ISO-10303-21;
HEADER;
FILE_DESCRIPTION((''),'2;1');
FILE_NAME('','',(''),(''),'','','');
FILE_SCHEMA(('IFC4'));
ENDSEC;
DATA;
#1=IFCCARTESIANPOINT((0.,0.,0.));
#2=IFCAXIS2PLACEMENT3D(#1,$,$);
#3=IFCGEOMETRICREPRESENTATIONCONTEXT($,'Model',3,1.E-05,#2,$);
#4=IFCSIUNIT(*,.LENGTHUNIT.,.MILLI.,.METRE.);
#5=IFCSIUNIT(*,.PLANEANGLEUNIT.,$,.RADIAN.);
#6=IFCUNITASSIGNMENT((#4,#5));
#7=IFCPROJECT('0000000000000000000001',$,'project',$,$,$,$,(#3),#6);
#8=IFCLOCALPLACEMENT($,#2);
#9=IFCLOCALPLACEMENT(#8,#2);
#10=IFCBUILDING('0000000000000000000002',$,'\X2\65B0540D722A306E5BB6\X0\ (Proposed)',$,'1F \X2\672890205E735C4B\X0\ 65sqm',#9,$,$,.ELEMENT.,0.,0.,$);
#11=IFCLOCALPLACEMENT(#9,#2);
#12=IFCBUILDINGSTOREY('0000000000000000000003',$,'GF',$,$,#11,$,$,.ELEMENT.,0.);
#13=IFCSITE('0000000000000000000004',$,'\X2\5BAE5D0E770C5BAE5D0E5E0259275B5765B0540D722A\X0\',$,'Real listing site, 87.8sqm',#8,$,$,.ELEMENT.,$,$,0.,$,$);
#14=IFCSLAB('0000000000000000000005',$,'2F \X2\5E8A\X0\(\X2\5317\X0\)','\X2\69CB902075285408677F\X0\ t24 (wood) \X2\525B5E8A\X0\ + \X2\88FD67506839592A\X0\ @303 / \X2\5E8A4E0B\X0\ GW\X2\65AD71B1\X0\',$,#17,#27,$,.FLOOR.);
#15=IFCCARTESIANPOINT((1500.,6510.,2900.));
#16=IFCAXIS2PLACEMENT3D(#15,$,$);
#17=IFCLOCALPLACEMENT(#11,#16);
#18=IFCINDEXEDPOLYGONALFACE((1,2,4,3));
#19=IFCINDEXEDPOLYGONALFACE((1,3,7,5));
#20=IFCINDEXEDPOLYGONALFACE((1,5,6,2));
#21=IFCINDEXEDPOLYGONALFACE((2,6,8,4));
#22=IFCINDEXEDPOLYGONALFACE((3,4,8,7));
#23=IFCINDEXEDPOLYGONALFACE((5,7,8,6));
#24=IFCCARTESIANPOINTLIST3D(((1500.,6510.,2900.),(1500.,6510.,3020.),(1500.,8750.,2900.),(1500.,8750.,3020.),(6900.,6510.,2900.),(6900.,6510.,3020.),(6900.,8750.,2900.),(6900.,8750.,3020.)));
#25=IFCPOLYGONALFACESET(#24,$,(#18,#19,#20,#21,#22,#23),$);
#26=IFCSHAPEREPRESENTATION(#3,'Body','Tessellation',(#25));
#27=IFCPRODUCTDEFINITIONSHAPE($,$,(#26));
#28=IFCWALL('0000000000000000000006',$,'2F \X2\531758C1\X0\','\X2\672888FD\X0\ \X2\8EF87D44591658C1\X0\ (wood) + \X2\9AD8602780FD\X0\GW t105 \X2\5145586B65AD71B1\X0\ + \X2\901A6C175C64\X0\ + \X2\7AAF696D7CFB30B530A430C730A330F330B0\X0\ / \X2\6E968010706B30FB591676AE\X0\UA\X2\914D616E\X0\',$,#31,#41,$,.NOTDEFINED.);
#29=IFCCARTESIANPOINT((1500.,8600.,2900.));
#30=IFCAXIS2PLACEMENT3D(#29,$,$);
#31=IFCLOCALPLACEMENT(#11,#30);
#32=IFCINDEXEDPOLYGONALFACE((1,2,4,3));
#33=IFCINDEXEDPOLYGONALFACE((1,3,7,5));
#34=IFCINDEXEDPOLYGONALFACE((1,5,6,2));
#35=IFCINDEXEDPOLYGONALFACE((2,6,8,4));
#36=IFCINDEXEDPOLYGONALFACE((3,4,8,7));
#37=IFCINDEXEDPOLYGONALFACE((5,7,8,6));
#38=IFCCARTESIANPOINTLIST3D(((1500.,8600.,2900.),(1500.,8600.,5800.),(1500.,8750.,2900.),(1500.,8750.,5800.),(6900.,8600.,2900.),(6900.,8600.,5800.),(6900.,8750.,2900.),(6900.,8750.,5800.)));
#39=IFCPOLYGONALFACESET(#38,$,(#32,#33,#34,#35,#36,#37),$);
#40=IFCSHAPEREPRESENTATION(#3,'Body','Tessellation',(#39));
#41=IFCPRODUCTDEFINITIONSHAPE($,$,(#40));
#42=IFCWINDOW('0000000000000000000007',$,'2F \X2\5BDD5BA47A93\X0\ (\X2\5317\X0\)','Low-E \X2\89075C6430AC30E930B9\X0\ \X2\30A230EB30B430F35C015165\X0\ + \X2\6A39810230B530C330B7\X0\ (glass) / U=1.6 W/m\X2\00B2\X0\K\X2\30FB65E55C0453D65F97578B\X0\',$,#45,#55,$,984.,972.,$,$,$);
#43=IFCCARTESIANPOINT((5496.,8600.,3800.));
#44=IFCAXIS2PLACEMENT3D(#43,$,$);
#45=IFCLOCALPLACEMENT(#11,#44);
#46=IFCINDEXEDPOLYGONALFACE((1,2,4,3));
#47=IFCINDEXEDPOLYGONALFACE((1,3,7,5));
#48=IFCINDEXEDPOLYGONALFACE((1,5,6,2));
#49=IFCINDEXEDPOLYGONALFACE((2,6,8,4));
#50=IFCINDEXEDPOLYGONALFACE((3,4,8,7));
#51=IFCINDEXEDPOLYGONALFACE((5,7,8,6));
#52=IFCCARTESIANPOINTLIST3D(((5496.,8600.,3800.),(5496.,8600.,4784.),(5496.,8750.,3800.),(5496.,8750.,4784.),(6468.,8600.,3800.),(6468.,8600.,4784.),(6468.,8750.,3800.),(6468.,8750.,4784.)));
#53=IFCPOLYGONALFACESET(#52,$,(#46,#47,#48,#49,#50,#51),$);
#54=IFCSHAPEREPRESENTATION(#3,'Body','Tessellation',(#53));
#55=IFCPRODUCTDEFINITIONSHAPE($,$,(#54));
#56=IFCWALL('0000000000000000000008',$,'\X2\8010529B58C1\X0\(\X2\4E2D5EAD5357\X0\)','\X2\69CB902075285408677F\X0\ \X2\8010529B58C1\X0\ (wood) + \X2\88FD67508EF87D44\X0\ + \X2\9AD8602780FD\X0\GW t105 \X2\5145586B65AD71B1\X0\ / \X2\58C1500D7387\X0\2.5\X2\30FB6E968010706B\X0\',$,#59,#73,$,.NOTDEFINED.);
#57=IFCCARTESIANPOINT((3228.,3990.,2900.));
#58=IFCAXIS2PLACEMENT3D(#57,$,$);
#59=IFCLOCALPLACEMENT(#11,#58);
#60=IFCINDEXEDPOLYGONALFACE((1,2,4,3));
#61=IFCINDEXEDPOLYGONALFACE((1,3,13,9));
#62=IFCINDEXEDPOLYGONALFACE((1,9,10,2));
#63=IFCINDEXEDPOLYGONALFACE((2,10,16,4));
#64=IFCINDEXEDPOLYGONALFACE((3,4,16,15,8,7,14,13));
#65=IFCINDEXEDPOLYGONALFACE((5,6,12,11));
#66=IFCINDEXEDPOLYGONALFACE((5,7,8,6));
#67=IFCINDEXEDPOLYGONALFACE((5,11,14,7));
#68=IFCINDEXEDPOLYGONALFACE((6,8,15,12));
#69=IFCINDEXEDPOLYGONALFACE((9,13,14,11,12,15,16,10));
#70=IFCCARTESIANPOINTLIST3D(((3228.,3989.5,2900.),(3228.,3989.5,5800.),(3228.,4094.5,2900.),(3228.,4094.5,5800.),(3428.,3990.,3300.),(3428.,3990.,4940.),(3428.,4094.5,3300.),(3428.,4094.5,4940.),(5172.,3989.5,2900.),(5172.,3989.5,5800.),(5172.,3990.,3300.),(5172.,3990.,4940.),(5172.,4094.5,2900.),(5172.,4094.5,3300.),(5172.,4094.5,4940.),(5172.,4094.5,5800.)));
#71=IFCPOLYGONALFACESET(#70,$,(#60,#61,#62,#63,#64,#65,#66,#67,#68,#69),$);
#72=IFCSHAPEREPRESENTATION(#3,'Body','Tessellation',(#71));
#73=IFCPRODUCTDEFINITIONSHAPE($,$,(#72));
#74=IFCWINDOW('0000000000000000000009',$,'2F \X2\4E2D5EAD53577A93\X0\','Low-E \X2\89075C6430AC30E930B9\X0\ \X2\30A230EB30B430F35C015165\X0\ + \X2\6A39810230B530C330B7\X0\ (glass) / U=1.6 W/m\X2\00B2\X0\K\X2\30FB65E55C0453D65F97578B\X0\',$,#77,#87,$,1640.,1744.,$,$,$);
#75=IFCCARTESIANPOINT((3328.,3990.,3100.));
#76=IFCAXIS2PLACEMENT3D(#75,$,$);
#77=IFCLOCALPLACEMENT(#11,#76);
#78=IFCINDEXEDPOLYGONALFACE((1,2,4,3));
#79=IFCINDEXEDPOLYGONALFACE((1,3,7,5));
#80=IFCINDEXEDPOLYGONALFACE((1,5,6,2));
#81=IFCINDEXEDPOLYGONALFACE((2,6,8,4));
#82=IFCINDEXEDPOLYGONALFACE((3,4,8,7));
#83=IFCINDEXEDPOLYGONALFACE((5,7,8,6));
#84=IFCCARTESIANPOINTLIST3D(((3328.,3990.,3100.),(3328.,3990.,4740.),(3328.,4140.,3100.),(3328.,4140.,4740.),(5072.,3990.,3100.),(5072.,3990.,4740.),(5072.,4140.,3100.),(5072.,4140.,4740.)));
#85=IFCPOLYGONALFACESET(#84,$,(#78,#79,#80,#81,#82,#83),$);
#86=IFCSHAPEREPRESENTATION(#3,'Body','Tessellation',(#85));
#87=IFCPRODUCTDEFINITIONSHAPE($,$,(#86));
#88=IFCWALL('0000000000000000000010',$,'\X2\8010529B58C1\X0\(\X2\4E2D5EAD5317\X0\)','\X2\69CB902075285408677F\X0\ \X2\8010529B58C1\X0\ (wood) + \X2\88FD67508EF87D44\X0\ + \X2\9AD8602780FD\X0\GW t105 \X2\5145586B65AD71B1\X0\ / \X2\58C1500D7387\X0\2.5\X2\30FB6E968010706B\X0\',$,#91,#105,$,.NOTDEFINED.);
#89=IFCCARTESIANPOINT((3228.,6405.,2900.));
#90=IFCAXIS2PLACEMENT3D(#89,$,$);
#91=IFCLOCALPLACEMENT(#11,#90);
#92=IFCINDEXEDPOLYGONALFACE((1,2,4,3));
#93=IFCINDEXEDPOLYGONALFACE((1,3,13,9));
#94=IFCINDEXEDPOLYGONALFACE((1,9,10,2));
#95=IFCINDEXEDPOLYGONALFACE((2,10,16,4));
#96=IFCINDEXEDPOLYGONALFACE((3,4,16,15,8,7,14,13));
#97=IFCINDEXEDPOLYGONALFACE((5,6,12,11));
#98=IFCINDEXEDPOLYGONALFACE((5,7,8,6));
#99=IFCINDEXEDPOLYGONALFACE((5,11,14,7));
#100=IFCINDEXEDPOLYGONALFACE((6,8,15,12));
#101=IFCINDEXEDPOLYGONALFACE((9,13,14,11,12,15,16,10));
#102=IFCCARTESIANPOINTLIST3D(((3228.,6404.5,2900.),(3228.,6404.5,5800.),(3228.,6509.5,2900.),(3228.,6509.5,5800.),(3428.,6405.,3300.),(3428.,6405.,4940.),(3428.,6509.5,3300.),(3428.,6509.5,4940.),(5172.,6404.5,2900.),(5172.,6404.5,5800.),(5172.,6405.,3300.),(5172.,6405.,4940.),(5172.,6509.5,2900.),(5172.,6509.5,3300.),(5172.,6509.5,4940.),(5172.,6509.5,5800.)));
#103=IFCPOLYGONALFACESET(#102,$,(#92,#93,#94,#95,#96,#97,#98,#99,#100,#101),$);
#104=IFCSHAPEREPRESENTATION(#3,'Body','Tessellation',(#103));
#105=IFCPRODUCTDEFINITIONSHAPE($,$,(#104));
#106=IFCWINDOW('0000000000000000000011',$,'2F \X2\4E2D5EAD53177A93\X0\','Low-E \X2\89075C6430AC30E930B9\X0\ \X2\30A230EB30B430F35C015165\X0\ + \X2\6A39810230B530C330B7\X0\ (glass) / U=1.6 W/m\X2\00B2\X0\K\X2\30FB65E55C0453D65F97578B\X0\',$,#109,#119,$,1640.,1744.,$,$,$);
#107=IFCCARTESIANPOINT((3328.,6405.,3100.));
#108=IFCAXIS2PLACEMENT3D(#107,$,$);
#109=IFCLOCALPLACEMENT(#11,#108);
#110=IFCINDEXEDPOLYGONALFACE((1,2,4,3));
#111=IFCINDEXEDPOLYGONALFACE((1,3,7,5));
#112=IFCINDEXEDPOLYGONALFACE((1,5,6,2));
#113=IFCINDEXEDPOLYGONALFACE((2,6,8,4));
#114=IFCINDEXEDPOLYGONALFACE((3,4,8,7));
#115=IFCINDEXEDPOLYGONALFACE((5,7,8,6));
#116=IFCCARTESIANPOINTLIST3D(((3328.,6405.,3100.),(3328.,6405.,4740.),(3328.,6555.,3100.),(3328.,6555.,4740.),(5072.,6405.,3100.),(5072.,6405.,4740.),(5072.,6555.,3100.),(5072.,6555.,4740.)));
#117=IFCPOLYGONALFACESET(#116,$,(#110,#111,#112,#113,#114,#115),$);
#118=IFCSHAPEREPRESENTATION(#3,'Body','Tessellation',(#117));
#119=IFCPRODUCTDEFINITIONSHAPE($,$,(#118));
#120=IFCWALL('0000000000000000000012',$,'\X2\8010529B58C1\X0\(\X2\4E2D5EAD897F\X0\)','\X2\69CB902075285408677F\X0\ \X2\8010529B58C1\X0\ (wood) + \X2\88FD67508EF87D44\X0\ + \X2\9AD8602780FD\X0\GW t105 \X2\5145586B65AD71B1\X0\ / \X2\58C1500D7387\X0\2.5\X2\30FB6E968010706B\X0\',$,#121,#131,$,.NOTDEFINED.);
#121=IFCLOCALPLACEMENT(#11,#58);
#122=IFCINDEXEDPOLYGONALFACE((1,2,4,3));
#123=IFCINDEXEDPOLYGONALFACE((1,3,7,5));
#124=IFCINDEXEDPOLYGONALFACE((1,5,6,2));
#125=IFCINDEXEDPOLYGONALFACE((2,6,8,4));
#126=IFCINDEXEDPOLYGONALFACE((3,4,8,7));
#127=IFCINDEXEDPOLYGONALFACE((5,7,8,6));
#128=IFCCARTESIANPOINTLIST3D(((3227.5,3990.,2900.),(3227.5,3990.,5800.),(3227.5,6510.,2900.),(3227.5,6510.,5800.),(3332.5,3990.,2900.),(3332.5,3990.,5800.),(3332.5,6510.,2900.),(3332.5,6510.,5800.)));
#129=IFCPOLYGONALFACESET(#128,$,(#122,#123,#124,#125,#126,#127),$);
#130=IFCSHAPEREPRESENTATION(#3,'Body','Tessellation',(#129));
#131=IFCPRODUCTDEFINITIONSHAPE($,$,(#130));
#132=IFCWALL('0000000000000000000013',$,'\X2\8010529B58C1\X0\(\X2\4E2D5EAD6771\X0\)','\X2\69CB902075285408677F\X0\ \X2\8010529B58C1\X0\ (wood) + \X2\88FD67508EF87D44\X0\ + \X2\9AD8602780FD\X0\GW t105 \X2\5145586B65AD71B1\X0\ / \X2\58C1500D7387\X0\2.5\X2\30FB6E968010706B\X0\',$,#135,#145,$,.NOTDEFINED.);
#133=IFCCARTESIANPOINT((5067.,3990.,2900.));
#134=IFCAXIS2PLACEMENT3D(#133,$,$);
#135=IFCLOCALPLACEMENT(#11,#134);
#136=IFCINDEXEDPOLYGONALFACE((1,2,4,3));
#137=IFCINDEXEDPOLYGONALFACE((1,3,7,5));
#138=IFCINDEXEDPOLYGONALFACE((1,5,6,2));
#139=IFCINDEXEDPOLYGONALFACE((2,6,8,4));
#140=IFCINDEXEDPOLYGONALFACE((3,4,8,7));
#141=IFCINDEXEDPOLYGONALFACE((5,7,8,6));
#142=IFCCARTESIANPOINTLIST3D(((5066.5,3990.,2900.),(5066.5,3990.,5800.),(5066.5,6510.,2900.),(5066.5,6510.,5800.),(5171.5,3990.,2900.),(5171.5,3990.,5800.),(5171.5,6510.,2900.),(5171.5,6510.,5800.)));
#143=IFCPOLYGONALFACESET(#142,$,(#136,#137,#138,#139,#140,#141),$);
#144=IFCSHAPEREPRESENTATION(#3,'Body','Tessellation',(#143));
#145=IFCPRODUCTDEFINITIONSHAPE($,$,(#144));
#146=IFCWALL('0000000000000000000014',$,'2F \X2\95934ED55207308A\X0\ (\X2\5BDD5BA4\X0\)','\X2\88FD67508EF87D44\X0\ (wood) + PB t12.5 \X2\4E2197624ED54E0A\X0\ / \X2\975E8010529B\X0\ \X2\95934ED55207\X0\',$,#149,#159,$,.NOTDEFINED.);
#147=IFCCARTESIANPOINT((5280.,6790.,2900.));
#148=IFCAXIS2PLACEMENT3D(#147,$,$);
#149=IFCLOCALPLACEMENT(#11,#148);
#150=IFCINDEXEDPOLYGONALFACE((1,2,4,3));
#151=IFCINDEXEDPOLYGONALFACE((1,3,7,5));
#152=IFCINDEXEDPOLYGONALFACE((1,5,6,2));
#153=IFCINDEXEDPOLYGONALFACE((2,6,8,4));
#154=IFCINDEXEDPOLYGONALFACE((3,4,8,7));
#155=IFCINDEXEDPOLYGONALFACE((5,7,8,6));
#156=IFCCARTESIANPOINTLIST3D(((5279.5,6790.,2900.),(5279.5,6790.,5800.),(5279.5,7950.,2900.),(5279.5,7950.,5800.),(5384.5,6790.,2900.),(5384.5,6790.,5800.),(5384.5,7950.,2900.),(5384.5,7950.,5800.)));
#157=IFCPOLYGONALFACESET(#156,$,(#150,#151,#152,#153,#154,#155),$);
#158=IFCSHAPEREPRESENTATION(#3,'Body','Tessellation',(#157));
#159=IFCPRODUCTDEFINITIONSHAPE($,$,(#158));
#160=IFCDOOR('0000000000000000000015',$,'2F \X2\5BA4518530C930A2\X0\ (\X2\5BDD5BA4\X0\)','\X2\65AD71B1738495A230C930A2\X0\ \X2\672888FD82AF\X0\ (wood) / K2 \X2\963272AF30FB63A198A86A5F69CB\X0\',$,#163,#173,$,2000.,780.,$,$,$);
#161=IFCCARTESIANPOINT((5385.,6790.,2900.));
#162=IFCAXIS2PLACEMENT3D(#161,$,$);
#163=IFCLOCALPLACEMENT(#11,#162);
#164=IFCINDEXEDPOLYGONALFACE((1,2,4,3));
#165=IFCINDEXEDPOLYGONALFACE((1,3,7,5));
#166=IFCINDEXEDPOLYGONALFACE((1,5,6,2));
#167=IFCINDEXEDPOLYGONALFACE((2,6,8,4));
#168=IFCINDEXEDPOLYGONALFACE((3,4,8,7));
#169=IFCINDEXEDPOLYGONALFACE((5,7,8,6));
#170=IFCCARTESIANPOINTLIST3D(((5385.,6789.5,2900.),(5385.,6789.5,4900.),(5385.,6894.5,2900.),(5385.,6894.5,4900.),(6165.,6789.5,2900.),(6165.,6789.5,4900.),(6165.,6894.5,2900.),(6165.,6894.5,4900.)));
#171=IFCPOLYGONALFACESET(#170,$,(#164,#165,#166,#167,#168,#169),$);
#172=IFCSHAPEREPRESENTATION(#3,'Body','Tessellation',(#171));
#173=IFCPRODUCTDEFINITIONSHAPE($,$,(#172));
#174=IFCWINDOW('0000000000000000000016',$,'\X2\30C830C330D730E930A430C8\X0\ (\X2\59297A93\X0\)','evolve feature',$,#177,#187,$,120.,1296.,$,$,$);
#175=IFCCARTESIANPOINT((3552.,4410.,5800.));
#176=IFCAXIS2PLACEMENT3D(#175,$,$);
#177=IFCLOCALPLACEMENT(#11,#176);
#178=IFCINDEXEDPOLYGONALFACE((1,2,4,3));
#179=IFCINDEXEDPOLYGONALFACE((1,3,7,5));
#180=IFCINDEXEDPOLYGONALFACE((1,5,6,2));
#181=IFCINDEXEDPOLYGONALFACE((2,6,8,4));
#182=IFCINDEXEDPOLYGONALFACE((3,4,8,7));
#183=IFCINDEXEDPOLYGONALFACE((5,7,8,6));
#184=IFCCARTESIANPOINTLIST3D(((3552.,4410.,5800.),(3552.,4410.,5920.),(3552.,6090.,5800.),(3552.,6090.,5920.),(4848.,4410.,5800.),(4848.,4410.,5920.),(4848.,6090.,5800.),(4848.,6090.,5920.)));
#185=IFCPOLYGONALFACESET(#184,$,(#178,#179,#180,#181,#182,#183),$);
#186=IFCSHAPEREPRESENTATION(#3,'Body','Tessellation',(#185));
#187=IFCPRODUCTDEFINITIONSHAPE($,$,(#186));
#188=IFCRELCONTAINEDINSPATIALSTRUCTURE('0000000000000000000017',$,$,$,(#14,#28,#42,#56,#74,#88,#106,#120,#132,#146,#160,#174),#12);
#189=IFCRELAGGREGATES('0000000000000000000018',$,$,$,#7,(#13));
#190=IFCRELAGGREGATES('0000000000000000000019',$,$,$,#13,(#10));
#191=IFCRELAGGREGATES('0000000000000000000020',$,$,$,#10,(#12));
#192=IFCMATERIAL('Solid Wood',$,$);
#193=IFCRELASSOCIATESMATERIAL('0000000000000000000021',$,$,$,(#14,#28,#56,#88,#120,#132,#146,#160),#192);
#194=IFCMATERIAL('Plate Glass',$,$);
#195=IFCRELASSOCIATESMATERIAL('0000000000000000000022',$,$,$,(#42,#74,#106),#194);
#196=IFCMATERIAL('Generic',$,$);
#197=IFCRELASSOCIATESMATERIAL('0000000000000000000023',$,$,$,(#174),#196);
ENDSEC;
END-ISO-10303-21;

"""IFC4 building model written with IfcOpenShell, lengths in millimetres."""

from ifc_helpers import new_model, si_unit, frame, frame_2d, origin, place, context, project, spatial, rectangle, extrude, material, element, fill, save


model = new_model("IFC4")

# Units and contexts
model_context = context("Model", 3, precision=1e-05, world=origin())
ifc_project = project(units=[si_unit("LENGTHUNIT", "METRE", prefix="MILLI"), si_unit("PLANEANGLEUNIT", "RADIAN")], contexts=[model_context])

# Site, building, storey
site_placement = place(None, origin())
site = spatial("IfcSite", under=ifc_project, at=site_placement, Name="宮崎県宮崎市大字新名爪", ObjectType="Real listing site, 87.8sqm", CompositionType="ELEMENT", RefElevation=0.0)
building_placement = place(site_placement, origin())
building = spatial("IfcBuilding", under=site, at=building_placement, Name="新名爪の家 (Proposed)", ObjectType="1F 木造平屋 65sqm", CompositionType="ELEMENT", ElevationOfRefHeight=0.0, ElevationOfTerrain=0.0)
storey_placement = place(building_placement, origin())
storey = spatial("IfcBuildingStorey", under=building, at=storey_placement, Name="GF", CompositionType="ELEMENT", Elevation=0.0)

# Slab
ifc_material_1 = material(Name="Solid Wood")
slab_placement = place(storey_placement, frame((1500.0, 6510.0, 2900.0)))
element("IfcSlab", 1, at=slab_placement, inside=storey, material=ifc_material_1, Name="2F 床(北)", Description="構造用合板 t24 (wood) 剛床 + 製材根太 @303 / 床下 GW断熱", PredefinedType="FLOOR", context=model_context, shape_type="SweptSolid", body=[
    extrude(rectangle(XDim=5400.0, YDim=2240.0, at=frame_2d((2700.0, 1120.0))), frame((1500.0, 6510.0, 2900.0)), (0.0, 0.0, 1.0), 120.0),
])

# Walls, openings, windows
wall_1_placement = place(storey_placement, frame((1500.0, 8600.0, 2900.0)))
wall_1 = element("IfcWall", 2, at=wall_1_placement, inside=storey, material=ifc_material_1, Name="2F 北壁", Description="木製 軸組外壁 (wood) + 高性能GW t105 充填断熱 + 通気層 + 窯業系サイディング / 準耐火・外皮UA配慮", PredefinedType="NOTDEFINED", context=model_context, shape_type="SweptSolid", body=[
    extrude(rectangle(XDim=5400.0, YDim=150.0, at=frame_2d((2700.0, 75.0))), frame((1500.0, 8600.0, 2900.0)), (0.0, 0.0, 1.0), 2900.0),
])
opening_1_placement = place(storey_placement, frame((5496.0, 8600.0, 3800.0)))
opening_1 = element("IfcOpeningElement", 3, at=opening_1_placement, cuts=wall_1, PredefinedType="NOTDEFINED", context=model_context, shape_type="SweptSolid", body=[
    extrude(rectangle(XDim=972.0, YDim=150.0, at=frame_2d((486.0, 75.0))), frame((5496.0, 8600.0, 3800.0)), (0.0, 0.0, 1.0), 984.0),
])
ifc_material_2 = material(Name="Plate Glass")
window_1_placement = place(storey_placement, frame((5496.0, 8600.0, 3800.0)))
window_1 = element("IfcWindow", 4, at=window_1_placement, inside=storey, material=ifc_material_2, Name="2F 寝室窓 (北)", Description="Low-E 複層ガラス アルゴン封入 + 樹脂サッシ (glass) / U=1.6 W/m²K・日射取得型", OverallHeight=984.0, OverallWidth=972.0, context=model_context, shape_type="SweptSolid", body=[
    extrude(rectangle(XDim=972.0, YDim=150.0, at=frame_2d((486.0, 75.0))), frame((5496.0, 8600.0, 3800.0)), (0.0, 0.0, 1.0), 984.0),
])
fill(opening_1, window_1)
wall_2_placement = place(storey_placement, frame((3228.0, 3990.0, 2900.0)))
wall_2 = element("IfcWall", 5, at=wall_2_placement, inside=storey, material=ifc_material_1, Name="耐力壁(中庭南)", Description="構造用合板 耐力壁 (wood) + 製材軸組 + 高性能GW t105 充填断熱 / 壁倍率2.5・準耐火", PredefinedType="NOTDEFINED", context=model_context, shape_type="SweptSolid", body=[
    extrude(rectangle(XDim=1944.0, YDim=105.0, at=frame_2d((972.0, 52.0))), frame((3228.0, 3990.0, 2900.0)), (0.0, 0.0, 1.0), 2900.0),
])
opening_2_placement = place(storey_placement, frame((3328.0, 3990.0, 3100.0)))
opening_2 = element("IfcOpeningElement", 6, at=opening_2_placement, cuts=wall_2, PredefinedType="NOTDEFINED", context=model_context, shape_type="SweptSolid", body=[
    extrude(rectangle(XDim=1744.0, YDim=150.0, at=frame_2d((872.0, 75.0))), frame((3328.0, 3990.0, 3100.0)), (0.0, 0.0, 1.0), 1640.0),
])
window_2_placement = place(storey_placement, frame((3328.0, 3990.0, 3100.0)))
window_2 = element("IfcWindow", 7, at=window_2_placement, inside=storey, material=ifc_material_2, Name="2F 中庭南窓", Description="Low-E 複層ガラス アルゴン封入 + 樹脂サッシ (glass) / U=1.6 W/m²K・日射取得型", OverallHeight=1640.0, OverallWidth=1744.0, context=model_context, shape_type="SweptSolid", body=[
    extrude(rectangle(XDim=1744.0, YDim=150.0, at=frame_2d((872.0, 75.0))), frame((3328.0, 3990.0, 3100.0)), (0.0, 0.0, 1.0), 1640.0),
])
fill(opening_2, window_2)
wall_3_placement = place(storey_placement, frame((3228.0, 6405.0, 2900.0)))
wall_3 = element("IfcWall", 8, at=wall_3_placement, inside=storey, material=ifc_material_1, Name="耐力壁(中庭北)", Description="構造用合板 耐力壁 (wood) + 製材軸組 + 高性能GW t105 充填断熱 / 壁倍率2.5・準耐火", PredefinedType="NOTDEFINED", context=model_context, shape_type="SweptSolid", body=[
    extrude(rectangle(XDim=1944.0, YDim=105.0, at=frame_2d((972.0, 52.0))), frame((3228.0, 6405.0, 2900.0)), (0.0, 0.0, 1.0), 2900.0),
])
opening_3_placement = place(storey_placement, frame((3328.0, 6405.0, 3100.0)))
opening_3 = element("IfcOpeningElement", 9, at=opening_3_placement, cuts=wall_3, PredefinedType="NOTDEFINED", context=model_context, shape_type="SweptSolid", body=[
    extrude(rectangle(XDim=1744.0, YDim=150.0, at=frame_2d((872.0, 75.0))), frame((3328.0, 6405.0, 3100.0)), (0.0, 0.0, 1.0), 1640.0),
])
window_3_placement = place(storey_placement, frame((3328.0, 6405.0, 3100.0)))
window_3 = element("IfcWindow", 10, at=window_3_placement, inside=storey, material=ifc_material_2, Name="2F 中庭北窓", Description="Low-E 複層ガラス アルゴン封入 + 樹脂サッシ (glass) / U=1.6 W/m²K・日射取得型", OverallHeight=1640.0, OverallWidth=1744.0, context=model_context, shape_type="SweptSolid", body=[
    extrude(rectangle(XDim=1744.0, YDim=150.0, at=frame_2d((872.0, 75.0))), frame((3328.0, 6405.0, 3100.0)), (0.0, 0.0, 1.0), 1640.0),
])
fill(opening_3, window_3)

# Walls
wall_4_placement = place(storey_placement, frame((3228.0, 3990.0, 2900.0)))
element("IfcWall", 11, at=wall_4_placement, inside=storey, material=ifc_material_1, Name="耐力壁(中庭西)", Description="構造用合板 耐力壁 (wood) + 製材軸組 + 高性能GW t105 充填断熱 / 壁倍率2.5・準耐火", PredefinedType="NOTDEFINED", context=model_context, shape_type="SweptSolid", body=[
    extrude(rectangle(XDim=105.0, YDim=2520.0, at=frame_2d((52.0, 1260.0))), frame((3228.0, 3990.0, 2900.0)), (0.0, 0.0, 1.0), 2900.0),
])
wall_5_placement = place(storey_placement, frame((5067.0, 3990.0, 2900.0)))
element("IfcWall", 12, at=wall_5_placement, inside=storey, material=ifc_material_1, Name="耐力壁(中庭東)", Description="構造用合板 耐力壁 (wood) + 製材軸組 + 高性能GW t105 充填断熱 / 壁倍率2.5・準耐火", PredefinedType="NOTDEFINED", context=model_context, shape_type="SweptSolid", body=[
    extrude(rectangle(XDim=105.0, YDim=2520.0, at=frame_2d((52.0, 1260.0))), frame((5067.0, 3990.0, 2900.0)), (0.0, 0.0, 1.0), 2900.0),
])
wall_6_placement = place(storey_placement, frame((5280.0, 6790.0, 2900.0)))
element("IfcWall", 13, at=wall_6_placement, inside=storey, material=ifc_material_1, Name="2F 間仕切り (寝室)", Description="製材軸組 (wood) + PB t12.5 両面仕上 / 非耐力 間仕切", PredefinedType="NOTDEFINED", context=model_context, shape_type="SweptSolid", body=[
    extrude(rectangle(XDim=105.0, YDim=1160.0, at=frame_2d((52.0, 580.0))), frame((5280.0, 6790.0, 2900.0)), (0.0, 0.0, 1.0), 2900.0),
])

# Door
door_placement = place(storey_placement, frame((5385.0, 6790.0, 2900.0)))
element("IfcDoor", 14, at=door_placement, inside=storey, material=ifc_material_1, Name="2F 室内ドア (寝室)", Description="断熱玄関ドア 木製芯 (wood) / K2 防犯・採風機構", OverallHeight=2000.0, OverallWidth=780.0, context=model_context, shape_type="SweptSolid", body=[
    extrude(rectangle(XDim=780.0, YDim=105.0, at=frame_2d((390.0, 52.0))), frame((5385.0, 6790.0, 2900.0)), (0.0, 0.0, 1.0), 2000.0),
])

# Window
ifc_material_3 = material(Name="Generic")
window_4_placement = place(storey_placement, frame((3552.0, 4410.0, 5800.0)))
element("IfcWindow", 15, at=window_4_placement, inside=storey, material=ifc_material_3, Name="トップライト (天窓)", Description="evolve feature", OverallHeight=120.0, OverallWidth=1296.0, context=model_context, shape_type="SweptSolid", body=[
    extrude(rectangle(XDim=1296.0, YDim=1680.0, at=frame_2d((648.0, 840.0))), frame((3552.0, 4410.0, 5800.0)), (0.0, 0.0, 1.0), 120.0),
])

save(model, "model.ifc")
